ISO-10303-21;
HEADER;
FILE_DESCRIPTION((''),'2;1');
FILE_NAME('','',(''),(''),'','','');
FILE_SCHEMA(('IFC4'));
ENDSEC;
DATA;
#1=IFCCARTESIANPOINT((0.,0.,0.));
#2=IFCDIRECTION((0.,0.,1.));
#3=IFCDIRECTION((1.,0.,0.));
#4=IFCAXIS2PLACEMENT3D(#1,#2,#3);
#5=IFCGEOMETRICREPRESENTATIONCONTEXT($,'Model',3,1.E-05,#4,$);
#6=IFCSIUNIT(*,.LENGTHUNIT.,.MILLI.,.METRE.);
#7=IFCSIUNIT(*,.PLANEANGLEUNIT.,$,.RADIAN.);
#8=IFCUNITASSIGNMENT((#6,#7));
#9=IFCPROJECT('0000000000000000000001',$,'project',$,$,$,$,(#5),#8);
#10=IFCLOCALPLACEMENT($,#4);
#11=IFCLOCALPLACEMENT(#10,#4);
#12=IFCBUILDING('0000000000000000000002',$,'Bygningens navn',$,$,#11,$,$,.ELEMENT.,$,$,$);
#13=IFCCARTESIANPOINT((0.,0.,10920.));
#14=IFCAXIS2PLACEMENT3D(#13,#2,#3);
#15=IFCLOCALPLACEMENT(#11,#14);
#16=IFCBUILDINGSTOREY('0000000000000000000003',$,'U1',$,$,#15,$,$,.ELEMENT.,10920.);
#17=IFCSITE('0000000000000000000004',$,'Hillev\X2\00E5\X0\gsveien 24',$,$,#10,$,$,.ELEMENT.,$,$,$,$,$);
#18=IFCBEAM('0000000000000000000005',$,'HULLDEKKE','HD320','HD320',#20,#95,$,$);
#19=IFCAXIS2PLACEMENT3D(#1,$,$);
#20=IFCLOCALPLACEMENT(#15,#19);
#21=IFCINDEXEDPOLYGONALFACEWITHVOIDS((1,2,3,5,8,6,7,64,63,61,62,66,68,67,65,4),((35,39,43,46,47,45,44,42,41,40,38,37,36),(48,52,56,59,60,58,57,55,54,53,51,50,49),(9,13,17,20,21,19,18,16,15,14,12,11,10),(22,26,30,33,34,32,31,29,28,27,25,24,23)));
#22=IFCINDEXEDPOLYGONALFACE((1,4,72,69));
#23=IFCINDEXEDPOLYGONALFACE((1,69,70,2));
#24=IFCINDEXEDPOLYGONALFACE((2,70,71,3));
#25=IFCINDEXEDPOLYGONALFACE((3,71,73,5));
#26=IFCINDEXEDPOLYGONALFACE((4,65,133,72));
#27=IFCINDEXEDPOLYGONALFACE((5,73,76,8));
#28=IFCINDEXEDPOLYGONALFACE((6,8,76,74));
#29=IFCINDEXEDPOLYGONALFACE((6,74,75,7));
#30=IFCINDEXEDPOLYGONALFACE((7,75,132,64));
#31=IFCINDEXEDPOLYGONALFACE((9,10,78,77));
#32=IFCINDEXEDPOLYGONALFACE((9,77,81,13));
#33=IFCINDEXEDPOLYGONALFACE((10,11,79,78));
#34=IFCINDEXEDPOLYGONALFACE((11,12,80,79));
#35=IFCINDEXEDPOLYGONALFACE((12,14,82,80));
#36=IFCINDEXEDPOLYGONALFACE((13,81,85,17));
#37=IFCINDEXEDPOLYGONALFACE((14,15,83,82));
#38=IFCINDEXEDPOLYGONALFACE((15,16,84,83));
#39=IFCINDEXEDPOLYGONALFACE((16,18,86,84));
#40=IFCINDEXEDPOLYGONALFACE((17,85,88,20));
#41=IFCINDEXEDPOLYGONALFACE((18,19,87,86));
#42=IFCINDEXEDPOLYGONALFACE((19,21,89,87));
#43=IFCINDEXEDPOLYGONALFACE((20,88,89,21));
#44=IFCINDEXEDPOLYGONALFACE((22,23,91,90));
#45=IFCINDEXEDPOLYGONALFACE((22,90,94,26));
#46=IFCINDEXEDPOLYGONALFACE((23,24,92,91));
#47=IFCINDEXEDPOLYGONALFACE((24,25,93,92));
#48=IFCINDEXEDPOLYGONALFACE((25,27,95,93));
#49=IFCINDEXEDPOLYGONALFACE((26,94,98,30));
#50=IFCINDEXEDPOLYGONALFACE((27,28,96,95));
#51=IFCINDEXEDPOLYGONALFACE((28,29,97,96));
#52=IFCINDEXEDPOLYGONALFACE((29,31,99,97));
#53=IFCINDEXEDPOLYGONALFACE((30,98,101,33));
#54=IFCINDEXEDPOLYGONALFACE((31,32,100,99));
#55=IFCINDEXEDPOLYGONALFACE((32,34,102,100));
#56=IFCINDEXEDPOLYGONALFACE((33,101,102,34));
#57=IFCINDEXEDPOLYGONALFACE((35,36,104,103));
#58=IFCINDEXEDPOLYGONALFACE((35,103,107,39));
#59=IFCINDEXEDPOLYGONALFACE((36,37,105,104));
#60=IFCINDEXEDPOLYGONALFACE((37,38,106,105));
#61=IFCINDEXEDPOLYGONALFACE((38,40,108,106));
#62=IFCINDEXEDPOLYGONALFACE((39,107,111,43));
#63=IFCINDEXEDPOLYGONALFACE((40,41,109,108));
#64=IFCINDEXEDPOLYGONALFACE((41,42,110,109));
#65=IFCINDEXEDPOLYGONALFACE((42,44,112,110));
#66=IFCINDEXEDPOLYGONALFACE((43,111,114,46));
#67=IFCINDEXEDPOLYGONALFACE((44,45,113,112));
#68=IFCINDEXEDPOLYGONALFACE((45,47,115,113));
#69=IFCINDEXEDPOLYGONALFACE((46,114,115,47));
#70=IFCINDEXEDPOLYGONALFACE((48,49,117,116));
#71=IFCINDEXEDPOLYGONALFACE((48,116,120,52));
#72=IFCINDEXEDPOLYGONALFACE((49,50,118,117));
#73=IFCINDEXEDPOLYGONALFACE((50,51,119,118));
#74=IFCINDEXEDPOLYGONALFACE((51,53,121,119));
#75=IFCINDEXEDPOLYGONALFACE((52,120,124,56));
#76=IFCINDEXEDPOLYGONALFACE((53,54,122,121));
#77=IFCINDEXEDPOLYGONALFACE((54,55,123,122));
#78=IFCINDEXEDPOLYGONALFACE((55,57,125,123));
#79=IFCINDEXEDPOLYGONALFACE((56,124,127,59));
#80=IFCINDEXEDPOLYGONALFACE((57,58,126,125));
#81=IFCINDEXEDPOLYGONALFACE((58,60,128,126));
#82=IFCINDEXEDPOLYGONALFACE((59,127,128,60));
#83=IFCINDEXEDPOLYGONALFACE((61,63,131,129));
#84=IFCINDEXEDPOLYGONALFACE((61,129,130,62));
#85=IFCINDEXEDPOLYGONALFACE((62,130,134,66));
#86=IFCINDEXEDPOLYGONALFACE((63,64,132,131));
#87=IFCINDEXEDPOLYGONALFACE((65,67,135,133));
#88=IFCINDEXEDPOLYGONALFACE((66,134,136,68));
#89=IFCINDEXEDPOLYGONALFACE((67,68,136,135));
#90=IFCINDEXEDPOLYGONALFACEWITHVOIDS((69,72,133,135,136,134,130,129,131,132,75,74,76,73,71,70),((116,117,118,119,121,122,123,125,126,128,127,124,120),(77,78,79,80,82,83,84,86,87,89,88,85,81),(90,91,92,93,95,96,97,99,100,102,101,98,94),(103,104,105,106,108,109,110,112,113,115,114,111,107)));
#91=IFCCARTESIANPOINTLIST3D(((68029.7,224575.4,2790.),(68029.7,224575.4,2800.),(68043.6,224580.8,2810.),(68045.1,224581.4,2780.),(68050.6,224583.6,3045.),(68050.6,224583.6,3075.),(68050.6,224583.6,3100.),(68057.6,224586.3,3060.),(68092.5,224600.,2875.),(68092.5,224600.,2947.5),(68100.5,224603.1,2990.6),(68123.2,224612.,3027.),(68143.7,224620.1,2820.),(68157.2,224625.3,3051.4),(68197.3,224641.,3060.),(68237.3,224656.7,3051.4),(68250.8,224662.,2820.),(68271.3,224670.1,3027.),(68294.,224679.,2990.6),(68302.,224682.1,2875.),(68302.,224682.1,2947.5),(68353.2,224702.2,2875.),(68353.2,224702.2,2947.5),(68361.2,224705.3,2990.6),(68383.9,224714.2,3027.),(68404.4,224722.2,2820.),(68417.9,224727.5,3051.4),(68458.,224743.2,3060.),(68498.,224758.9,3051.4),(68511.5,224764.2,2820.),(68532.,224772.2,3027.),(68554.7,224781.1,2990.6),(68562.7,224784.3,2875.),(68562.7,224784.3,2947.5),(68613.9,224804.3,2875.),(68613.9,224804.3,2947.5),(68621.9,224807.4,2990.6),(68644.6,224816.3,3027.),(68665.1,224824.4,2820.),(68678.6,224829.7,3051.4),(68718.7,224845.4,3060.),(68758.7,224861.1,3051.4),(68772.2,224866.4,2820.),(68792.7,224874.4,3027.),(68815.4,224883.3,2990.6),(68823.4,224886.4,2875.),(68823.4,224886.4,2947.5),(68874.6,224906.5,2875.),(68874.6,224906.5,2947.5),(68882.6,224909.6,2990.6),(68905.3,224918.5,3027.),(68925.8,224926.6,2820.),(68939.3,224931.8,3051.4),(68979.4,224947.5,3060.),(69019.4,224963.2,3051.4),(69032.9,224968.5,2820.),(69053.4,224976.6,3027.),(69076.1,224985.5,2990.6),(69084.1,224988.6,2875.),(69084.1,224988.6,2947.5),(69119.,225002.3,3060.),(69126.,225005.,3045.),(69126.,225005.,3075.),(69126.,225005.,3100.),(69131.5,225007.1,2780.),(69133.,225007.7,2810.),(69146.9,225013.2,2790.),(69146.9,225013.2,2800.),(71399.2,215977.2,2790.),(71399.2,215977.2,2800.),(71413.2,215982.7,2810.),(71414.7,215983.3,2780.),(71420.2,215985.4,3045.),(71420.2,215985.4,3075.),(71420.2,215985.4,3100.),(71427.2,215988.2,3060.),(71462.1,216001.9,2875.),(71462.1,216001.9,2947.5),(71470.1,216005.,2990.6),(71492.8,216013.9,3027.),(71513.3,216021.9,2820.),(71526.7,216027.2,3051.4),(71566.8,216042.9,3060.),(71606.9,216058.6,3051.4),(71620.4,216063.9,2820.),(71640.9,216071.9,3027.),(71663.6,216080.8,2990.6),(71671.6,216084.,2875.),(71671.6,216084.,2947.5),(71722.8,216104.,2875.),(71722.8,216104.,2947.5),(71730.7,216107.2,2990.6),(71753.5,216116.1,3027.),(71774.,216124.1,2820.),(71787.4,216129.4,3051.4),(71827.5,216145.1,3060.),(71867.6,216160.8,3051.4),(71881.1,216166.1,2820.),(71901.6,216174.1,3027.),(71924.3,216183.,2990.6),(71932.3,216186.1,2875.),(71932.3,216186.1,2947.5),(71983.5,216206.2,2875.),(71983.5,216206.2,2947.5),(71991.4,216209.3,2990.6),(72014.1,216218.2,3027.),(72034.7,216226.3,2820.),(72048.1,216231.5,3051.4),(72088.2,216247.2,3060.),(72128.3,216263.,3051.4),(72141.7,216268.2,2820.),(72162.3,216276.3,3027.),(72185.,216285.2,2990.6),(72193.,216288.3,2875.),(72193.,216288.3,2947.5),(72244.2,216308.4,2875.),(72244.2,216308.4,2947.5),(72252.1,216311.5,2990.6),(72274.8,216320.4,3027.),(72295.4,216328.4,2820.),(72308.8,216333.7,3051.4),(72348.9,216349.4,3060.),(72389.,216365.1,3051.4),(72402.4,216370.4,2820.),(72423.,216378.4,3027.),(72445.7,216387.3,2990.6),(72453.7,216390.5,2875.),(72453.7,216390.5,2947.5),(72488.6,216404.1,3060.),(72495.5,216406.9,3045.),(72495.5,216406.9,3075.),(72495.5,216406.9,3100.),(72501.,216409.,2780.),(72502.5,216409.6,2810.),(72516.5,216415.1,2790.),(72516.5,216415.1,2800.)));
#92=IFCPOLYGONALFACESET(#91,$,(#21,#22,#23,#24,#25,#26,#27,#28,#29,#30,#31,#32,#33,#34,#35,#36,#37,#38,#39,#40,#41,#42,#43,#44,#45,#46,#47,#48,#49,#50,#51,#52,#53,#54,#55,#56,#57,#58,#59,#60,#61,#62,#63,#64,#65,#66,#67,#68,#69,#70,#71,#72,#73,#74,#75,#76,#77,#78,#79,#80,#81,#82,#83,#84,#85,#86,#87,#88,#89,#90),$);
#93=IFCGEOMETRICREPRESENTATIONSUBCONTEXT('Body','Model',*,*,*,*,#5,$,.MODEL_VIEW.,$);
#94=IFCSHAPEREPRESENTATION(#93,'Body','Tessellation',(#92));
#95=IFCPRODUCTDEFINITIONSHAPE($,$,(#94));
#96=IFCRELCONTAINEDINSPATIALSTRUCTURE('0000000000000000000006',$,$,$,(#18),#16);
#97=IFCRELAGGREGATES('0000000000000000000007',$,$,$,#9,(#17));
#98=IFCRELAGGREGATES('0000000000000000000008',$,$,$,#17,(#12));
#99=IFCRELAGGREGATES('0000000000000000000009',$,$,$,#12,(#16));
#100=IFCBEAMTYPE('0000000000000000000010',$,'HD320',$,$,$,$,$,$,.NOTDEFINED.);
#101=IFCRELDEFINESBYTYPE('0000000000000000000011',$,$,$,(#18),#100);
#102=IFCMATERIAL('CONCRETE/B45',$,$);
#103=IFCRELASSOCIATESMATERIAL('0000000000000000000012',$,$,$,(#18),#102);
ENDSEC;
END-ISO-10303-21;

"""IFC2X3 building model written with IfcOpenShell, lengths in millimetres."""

from ifc_helpers import new_model, si_unit, frame, origin_with_axes, place, context, subcontext, project, spatial, polyline, outline, extrude, material, type_object, element, save


model = new_model("IFC2X3")

# Units and contexts
model_context = context("Model", 3, precision=1e-05, world=origin_with_axes())
body_context = subcontext(model_context, "Body", "Model", "MODEL_VIEW")
ifc_project = project(units=[si_unit("LENGTHUNIT", "METRE", prefix="MILLI"), si_unit("PLANEANGLEUNIT", "RADIAN")], contexts=[model_context])

# Site, building, storey
site_placement = place(None, origin_with_axes())
site = spatial("IfcSite", under=ifc_project, at=site_placement, Name="Hillevågsveien 24", CompositionType="ELEMENT")
building_placement = place(site_placement, origin_with_axes())
building = spatial("IfcBuilding", under=site, at=building_placement, Name="Bygningens navn", CompositionType="ELEMENT")
storey_placement = place(building_placement, frame((0.0, 0.0, 10920.0), z_axis=(0.0, 0.0, 1.0), x_axis=(1.0, 0.0, 0.0)))
storey = spatial("IfcBuildingStorey", under=building, at=storey_placement, Name="U1", CompositionType="ELEMENT", Elevation=10920.0)

# Beam
ifc_material_1 = material(Name="CONCRETE/B45")
beam_type_1 = type_object("IfcBeamType", Name="HD320", PredefinedType="NOTDEFINED")
beam_1_placement = place(storey_placement, frame((71957.9, 216196.2, 2940.0), z_axis=(0.0, 0.0, 1.0), x_axis=(-0.364876, 0.931056, 0.0)))
element("IfcBeam", 1, at=beam_1_placement, inside=storey, type_object=beam_type_1, material=ifc_material_1, Name="HULLDEKKE", Description="HD320", ObjectType="HD320", context=body_context, shape_type="SweptSolid", body=[
    extrude(outline(polyline([(577.5, 105.0), (585.0, -130.0), (600.0, -140.0), (600.0, -150.0), (583.4, -160.0), (-583.4, -160.0), (-600.0, -150.0), (-600.0, -140.0), (-585.0, -130.0), (-577.5, 105.0), (-570.0, 120.0), (-577.5, 135.0), (-577.5, 160.0), (577.5, 160.0), (577.5, 135.0), (570.0, 120.0), (577.5, 105.0)]), holes=[polyline([(477.5, -120.0), (532.5, -65.0), (532.5, 7.5), (523.9, 50.6), (499.5, 87.0), (463.1, 111.4), (420.0, 120.0), (376.9, 111.4), (340.5, 87.0), (316.1, 50.6), (307.5, 7.5), (307.5, -65.0), (362.5, -120.0), (477.5, -120.0)]), polyline([(197.5, -120.0), (252.5, -65.0), (252.5, 7.5), (243.9, 50.6), (219.5, 87.0), (183.1, 111.4), (140.0, 120.0), (96.9, 111.4), (60.5, 87.0), (36.1, 50.6), (27.5, 7.5), (27.5, -65.0), (82.5, -120.0), (197.5, -120.0)]), polyline([(-82.5, -120.0), (-27.5, -65.0), (-27.5, 7.5), (-36.1, 50.6), (-60.5, 87.0), (-96.9, 111.4), (-140.0, 120.0), (-183.1, 111.4), (-219.5, 87.0), (-243.9, 50.6), (-252.5, 7.5), (-252.5, -65.0), (-197.5, -120.0), (-82.5, -120.0)]), polyline([(-362.5, -120.0), (-307.5, -65.0), (-307.5, 7.5), (-316.1, 50.6), (-340.5, 87.0), (-376.9, 111.4), (-420.0, 120.0), (-463.1, 111.4), (-499.5, 87.0), (-523.9, 50.6), (-532.5, 7.5), (-532.5, -65.0), (-477.5, -120.0), (-362.5, -120.0)])]), frame((9234.8, 0.0, 0.0), z_axis=(-1.0, 0.0, 0.0), x_axis=(0.0, -1.0, 0.0)), (0.0, 0.0, 1.0), 9234.8),
])

save(model, "model.ifc")
